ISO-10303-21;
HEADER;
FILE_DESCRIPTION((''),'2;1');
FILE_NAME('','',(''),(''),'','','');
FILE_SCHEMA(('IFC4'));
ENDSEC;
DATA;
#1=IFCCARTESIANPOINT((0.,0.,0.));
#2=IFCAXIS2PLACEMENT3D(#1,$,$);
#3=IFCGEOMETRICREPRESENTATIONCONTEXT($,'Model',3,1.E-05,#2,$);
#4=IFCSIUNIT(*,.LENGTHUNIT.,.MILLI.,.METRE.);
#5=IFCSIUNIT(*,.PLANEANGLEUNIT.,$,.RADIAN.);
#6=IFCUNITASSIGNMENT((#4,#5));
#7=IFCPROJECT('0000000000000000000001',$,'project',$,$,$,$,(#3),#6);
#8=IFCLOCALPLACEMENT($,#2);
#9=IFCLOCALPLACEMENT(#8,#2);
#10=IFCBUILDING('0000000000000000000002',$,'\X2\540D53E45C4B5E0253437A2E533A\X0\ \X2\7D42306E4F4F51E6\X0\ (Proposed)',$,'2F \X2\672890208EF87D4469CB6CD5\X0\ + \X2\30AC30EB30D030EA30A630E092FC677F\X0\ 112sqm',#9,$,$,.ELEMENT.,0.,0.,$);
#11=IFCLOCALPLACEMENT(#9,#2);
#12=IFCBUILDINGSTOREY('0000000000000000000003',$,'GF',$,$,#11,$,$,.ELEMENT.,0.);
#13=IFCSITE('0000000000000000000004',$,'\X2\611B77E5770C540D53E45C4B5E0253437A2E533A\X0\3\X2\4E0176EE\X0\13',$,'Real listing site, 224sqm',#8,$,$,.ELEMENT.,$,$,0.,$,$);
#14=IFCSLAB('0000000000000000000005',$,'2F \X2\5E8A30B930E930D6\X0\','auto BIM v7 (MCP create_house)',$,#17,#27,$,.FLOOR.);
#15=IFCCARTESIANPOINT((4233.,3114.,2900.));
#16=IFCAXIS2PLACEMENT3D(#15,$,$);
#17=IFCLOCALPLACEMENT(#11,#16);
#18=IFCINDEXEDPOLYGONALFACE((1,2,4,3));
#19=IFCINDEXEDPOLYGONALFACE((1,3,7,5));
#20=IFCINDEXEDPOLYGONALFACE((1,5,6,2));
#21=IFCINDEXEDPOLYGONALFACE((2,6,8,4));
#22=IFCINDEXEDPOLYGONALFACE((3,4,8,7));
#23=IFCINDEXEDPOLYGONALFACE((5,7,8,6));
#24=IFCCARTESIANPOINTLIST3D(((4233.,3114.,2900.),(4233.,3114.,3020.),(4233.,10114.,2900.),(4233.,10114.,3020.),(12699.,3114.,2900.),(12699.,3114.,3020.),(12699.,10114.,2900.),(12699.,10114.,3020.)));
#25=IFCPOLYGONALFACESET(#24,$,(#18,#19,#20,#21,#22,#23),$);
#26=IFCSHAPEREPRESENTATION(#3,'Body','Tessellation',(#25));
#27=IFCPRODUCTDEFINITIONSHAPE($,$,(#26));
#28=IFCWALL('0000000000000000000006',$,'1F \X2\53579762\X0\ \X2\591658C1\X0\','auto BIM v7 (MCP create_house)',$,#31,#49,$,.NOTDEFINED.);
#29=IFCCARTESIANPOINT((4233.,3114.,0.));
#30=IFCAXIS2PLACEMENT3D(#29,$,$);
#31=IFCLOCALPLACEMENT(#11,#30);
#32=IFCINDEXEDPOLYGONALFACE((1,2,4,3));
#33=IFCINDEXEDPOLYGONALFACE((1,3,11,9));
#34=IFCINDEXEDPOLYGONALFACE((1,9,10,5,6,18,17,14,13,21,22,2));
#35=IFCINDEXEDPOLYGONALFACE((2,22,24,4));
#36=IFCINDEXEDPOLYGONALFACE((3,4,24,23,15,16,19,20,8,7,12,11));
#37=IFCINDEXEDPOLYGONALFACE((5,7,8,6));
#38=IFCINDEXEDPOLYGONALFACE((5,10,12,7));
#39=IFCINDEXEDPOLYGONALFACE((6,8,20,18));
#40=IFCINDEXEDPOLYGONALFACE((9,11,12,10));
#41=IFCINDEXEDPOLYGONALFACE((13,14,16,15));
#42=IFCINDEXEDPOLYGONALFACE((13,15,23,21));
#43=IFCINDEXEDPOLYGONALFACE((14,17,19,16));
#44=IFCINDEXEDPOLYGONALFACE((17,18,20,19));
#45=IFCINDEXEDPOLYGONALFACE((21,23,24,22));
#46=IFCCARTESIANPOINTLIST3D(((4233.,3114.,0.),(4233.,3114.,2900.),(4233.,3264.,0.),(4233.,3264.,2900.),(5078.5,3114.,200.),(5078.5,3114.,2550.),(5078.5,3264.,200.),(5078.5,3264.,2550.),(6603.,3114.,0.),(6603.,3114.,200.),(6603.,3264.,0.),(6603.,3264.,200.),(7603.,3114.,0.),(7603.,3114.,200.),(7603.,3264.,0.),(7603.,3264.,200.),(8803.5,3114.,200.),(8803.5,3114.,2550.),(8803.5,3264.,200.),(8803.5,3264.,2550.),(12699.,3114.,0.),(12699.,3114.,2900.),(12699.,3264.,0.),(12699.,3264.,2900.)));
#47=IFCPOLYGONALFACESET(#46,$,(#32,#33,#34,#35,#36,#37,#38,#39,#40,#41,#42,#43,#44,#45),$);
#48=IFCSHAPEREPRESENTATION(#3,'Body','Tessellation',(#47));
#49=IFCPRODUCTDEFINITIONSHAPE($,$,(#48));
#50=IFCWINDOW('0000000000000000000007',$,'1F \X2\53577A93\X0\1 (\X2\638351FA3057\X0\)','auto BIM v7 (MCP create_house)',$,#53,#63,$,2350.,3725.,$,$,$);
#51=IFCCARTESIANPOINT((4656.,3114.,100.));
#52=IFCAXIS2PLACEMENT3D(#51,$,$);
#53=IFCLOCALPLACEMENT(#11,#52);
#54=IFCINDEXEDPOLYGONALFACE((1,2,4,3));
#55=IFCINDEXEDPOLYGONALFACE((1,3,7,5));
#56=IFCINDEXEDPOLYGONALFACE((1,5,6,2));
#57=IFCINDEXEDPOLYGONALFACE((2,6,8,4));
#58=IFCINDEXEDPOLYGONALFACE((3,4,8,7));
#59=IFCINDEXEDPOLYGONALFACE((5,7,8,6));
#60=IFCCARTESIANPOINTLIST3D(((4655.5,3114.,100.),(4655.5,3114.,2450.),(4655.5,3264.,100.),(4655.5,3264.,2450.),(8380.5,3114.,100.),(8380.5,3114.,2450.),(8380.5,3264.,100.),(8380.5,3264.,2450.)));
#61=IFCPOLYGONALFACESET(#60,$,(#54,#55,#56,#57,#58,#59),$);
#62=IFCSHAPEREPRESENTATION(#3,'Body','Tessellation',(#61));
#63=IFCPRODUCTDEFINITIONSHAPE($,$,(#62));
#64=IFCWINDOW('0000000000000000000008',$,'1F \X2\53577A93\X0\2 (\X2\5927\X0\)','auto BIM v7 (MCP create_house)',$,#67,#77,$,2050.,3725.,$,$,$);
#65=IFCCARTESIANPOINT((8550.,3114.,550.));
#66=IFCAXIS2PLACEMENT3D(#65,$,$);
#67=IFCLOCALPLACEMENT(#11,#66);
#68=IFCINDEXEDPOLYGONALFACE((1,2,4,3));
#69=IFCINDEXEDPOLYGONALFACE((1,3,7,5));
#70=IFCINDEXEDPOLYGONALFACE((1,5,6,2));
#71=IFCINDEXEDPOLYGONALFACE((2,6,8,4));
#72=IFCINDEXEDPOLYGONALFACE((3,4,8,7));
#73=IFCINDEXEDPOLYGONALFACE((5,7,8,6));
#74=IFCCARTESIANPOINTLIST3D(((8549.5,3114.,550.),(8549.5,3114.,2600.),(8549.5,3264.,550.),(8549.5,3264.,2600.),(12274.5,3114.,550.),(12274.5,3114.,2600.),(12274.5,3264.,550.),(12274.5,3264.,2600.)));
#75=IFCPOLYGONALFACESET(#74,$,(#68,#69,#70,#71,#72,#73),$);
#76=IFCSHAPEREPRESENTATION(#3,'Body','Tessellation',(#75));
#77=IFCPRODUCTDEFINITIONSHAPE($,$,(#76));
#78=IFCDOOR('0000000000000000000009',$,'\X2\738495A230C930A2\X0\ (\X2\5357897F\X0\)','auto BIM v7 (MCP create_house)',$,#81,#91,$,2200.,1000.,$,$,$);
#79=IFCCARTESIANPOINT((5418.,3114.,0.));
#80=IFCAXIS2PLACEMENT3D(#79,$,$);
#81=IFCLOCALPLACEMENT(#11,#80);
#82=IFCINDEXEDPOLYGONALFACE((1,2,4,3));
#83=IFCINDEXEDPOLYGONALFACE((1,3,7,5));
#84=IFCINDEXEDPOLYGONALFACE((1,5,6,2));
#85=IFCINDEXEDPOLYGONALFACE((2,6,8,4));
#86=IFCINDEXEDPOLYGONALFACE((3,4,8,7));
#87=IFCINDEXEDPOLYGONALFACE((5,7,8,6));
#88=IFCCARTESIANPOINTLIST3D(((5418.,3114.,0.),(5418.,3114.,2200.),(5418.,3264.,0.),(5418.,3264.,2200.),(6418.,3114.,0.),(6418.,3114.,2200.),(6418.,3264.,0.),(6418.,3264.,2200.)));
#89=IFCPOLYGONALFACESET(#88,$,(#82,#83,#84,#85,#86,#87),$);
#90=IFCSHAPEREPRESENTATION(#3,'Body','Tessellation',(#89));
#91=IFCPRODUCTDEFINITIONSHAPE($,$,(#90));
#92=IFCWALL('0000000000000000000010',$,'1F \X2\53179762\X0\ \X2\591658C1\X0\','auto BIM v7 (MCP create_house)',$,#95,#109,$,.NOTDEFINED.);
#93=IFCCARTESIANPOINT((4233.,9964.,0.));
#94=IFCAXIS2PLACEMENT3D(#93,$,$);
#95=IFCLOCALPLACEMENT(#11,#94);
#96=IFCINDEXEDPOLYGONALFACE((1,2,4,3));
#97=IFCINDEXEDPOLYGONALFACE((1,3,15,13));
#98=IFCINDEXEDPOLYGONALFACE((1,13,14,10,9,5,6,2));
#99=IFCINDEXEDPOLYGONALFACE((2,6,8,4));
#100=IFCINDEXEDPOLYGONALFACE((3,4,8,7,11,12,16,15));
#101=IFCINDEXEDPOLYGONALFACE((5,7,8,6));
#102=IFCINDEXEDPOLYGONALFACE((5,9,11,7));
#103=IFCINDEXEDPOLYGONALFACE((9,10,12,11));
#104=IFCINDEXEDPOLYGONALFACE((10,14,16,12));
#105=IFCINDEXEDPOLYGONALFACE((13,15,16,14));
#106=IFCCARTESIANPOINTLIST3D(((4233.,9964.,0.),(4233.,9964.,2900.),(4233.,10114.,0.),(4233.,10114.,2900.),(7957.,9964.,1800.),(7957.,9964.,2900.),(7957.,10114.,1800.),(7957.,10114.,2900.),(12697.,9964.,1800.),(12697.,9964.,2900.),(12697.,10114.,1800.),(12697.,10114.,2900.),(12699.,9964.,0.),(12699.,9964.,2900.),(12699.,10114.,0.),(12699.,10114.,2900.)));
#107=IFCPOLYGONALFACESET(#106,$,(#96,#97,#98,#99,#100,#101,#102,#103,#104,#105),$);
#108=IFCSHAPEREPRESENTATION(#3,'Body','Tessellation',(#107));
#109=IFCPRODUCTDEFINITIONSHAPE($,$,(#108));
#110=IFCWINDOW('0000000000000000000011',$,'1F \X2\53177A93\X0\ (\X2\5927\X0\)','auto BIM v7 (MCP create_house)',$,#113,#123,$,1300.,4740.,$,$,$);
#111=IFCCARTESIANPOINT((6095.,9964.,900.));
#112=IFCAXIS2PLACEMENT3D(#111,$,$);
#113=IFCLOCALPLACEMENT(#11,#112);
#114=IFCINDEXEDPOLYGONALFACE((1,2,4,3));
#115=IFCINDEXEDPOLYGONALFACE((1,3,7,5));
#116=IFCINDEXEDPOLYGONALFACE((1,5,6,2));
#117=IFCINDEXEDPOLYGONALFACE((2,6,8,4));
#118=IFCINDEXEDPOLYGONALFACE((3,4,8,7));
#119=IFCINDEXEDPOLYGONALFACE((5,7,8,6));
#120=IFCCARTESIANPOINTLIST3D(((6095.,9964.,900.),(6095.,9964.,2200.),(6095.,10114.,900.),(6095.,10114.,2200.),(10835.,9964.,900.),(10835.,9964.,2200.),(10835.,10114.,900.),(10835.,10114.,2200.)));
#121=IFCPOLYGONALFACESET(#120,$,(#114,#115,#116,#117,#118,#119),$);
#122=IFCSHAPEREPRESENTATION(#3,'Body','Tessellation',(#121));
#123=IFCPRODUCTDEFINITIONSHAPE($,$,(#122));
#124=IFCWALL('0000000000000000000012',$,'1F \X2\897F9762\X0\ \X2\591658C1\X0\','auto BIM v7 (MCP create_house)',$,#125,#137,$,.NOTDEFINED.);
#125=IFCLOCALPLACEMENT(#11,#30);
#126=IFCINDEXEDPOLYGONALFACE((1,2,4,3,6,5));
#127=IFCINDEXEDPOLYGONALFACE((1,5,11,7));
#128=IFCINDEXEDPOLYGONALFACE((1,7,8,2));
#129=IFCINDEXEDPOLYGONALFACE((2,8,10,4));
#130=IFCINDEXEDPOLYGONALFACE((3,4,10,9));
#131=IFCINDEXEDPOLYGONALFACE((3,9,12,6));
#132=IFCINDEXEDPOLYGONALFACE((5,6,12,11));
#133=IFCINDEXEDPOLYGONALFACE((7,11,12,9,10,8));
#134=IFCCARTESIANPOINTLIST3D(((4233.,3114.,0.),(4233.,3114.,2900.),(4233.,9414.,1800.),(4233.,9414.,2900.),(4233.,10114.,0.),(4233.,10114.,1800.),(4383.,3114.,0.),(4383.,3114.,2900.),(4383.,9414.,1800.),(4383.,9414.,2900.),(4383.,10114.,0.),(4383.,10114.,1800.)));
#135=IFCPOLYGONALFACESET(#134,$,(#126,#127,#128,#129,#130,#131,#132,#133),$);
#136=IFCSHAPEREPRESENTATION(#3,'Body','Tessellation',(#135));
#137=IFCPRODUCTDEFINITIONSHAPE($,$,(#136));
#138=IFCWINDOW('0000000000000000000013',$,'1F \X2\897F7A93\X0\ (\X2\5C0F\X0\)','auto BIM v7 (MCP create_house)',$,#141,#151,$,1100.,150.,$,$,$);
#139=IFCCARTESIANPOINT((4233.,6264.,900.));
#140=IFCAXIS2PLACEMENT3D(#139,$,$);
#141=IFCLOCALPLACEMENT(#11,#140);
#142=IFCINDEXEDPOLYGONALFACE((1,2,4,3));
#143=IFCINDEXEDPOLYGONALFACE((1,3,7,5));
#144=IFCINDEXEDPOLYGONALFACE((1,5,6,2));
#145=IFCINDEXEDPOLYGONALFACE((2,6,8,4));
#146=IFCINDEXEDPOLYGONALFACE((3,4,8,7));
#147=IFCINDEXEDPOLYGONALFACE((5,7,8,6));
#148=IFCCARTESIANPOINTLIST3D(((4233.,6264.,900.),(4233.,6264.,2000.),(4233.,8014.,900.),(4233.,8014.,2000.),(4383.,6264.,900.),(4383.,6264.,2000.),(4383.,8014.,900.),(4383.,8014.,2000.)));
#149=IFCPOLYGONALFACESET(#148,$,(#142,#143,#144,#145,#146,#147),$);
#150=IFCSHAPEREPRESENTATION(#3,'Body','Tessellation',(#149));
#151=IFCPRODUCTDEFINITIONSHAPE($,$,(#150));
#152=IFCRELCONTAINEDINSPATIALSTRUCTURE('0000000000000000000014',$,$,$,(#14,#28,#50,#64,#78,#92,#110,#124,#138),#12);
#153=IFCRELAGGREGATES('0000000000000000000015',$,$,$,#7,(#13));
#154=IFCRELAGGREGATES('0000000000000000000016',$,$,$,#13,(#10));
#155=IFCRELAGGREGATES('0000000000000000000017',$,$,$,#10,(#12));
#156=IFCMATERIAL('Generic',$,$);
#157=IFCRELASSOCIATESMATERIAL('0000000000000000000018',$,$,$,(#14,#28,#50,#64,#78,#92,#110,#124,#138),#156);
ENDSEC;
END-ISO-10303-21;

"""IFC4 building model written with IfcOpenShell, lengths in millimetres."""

from ifc_helpers import new_model, si_unit, frame, frame_2d, origin, place, context, project, spatial, rectangle, extrude, material, element, fill, save


model = new_model("IFC4")

# Units and contexts
model_context = context("Model", 3, precision=1e-05, world=origin())
ifc_project = project(units=[si_unit("LENGTHUNIT", "METRE", prefix="MILLI"), si_unit("PLANEANGLEUNIT", "RADIAN")], contexts=[model_context])

# Site, building, storey
site_placement = place(None, origin())
site = spatial("IfcSite", under=ifc_project, at=site_placement, Name="愛知県名古屋市千種区3丁目13", ObjectType="Real listing site, 224sqm", CompositionType="ELEMENT", RefElevation=0.0)
building_placement = place(site_placement, origin())
building = spatial("IfcBuilding", under=site, at=building_placement, Name="名古屋市千種区 終の住処 (Proposed)", ObjectType="2F 木造軸組構法 + ガルバリウム鋼板 112sqm", CompositionType="ELEMENT", ElevationOfRefHeight=0.0, ElevationOfTerrain=0.0)
storey_placement = place(building_placement, origin())
storey = spatial("IfcBuildingStorey", under=building, at=storey_placement, Name="GF", CompositionType="ELEMENT", Elevation=0.0)

# Slab
ifc_material = material(Name="Generic")
slab_1_placement = place(storey_placement, frame((4233.0, 3114.0, 2900.0)))
element("IfcSlab", 1, at=slab_1_placement, inside=storey, material=ifc_material, Name="2F 床スラブ", Description="auto BIM v7 (MCP create_house)", PredefinedType="FLOOR", context=model_context, shape_type="SweptSolid", body=[
    extrude(rectangle(XDim=8466.0, YDim=7000.0, at=frame_2d((4233.0, 3500.0))), frame((4233.0, 3114.0, 2900.0)), (0.0, 0.0, 1.0), 120.0),
])

# Wall, openings, windows, door
wall_1_placement = place(storey_placement, frame((4233.0, 3114.0, 0.0)))
wall_1 = element("IfcWall", 2, at=wall_1_placement, inside=storey, material=ifc_material, Name="1F 南面 外壁", Description="auto BIM v7 (MCP create_house)", PredefinedType="NOTDEFINED", context=model_context, shape_type="SweptSolid", body=[
    extrude(rectangle(XDim=8466.0, YDim=150.0, at=frame_2d((4233.0, 75.0))), frame((4233.0, 3114.0, 0.0)), (0.0, 0.0, 1.0), 2900.0),
])
opening_1_placement = place(storey_placement, frame((4656.0, 3114.0, 100.0)))
opening_1 = element("IfcOpeningElement", 3, at=opening_1_placement, cuts=wall_1, PredefinedType="NOTDEFINED", context=model_context, shape_type="SweptSolid", body=[
    extrude(rectangle(XDim=3725.0, YDim=150.0, at=frame_2d((1862.0, 75.0))), frame((4656.0, 3114.0, 100.0)), (0.0, 0.0, 1.0), 2350.0),
])
opening_2_placement = place(storey_placement, frame((8550.0, 3114.0, 550.0)))
opening_2 = element("IfcOpeningElement", 4, at=opening_2_placement, cuts=wall_1, PredefinedType="NOTDEFINED", context=model_context, shape_type="SweptSolid", body=[
    extrude(rectangle(XDim=3725.0, YDim=150.0, at=frame_2d((1862.0, 75.0))), frame((8550.0, 3114.0, 550.0)), (0.0, 0.0, 1.0), 2050.0),
])
opening_3_placement = place(storey_placement, frame((5418.0, 3114.0, 0.0)))
opening_3 = element("IfcOpeningElement", 5, at=opening_3_placement, cuts=wall_1, PredefinedType="NOTDEFINED", context=model_context, shape_type="SweptSolid", body=[
    extrude(rectangle(XDim=1000.0, YDim=150.0, at=frame_2d((500.0, 75.0))), frame((5418.0, 3114.0, 0.0)), (0.0, 0.0, 1.0), 2200.0),
])
window_1_placement = place(storey_placement, frame((4656.0, 3114.0, 100.0)))
window_1 = element("IfcWindow", 6, at=window_1_placement, inside=storey, material=ifc_material, Name="1F 南窓1 (掃出し)", Description="auto BIM v7 (MCP create_house)", OverallHeight=2350.0, OverallWidth=3725.0, context=model_context, shape_type="SweptSolid", body=[
    extrude(rectangle(XDim=3725.0, YDim=150.0, at=frame_2d((1862.0, 75.0))), frame((4656.0, 3114.0, 100.0)), (0.0, 0.0, 1.0), 2350.0),
])
fill(opening_1, window_1)
window_2_placement = place(storey_placement, frame((8550.0, 3114.0, 550.0)))
window_2 = element("IfcWindow", 7, at=window_2_placement, inside=storey, material=ifc_material, Name="1F 南窓2 (大)", Description="auto BIM v7 (MCP create_house)", OverallHeight=2050.0, OverallWidth=3725.0, context=model_context, shape_type="SweptSolid", body=[
    extrude(rectangle(XDim=3725.0, YDim=150.0, at=frame_2d((1862.0, 75.0))), frame((8550.0, 3114.0, 550.0)), (0.0, 0.0, 1.0), 2050.0),
])
fill(opening_2, window_2)
door_placement = place(storey_placement, frame((5418.0, 3114.0, 0.0)))
door = element("IfcDoor", 8, at=door_placement, inside=storey, material=ifc_material, Name="玄関ドア (南西)", Description="auto BIM v7 (MCP create_house)", OverallHeight=2200.0, OverallWidth=1000.0, context=model_context, shape_type="SweptSolid", body=[
    extrude(rectangle(XDim=1000.0, YDim=150.0, at=frame_2d((500.0, 75.0))), frame((5418.0, 3114.0, 0.0)), (0.0, 0.0, 1.0), 2200.0),
])
fill(opening_3, door)

# Walls, openings, windows
wall_2_placement = place(storey_placement, frame((4233.0, 9964.0, 0.0)))
wall_2 = element("IfcWall", 9, at=wall_2_placement, inside=storey, material=ifc_material, Name="1F 北面 外壁", Description="auto BIM v7 (MCP create_house)", PredefinedType="NOTDEFINED", context=model_context, shape_type="SweptSolid", body=[
    extrude(rectangle(XDim=8466.0, YDim=150.0, at=frame_2d((4233.0, 75.0))), frame((4233.0, 9964.0, 0.0)), (0.0, 0.0, 1.0), 2900.0),
])
opening_4_placement = place(storey_placement, frame((6095.0, 9964.0, 900.0)))
opening_4 = element("IfcOpeningElement", 10, at=opening_4_placement, cuts=wall_2, PredefinedType="NOTDEFINED", context=model_context, shape_type="SweptSolid", body=[
    extrude(rectangle(XDim=4740.0, YDim=150.0, at=frame_2d((2370.0, 75.0))), frame((6095.0, 9964.0, 900.0)), (0.0, 0.0, 1.0), 1300.0),
])
window_3_placement = place(storey_placement, frame((6095.0, 9964.0, 900.0)))
window_3 = element("IfcWindow", 11, at=window_3_placement, inside=storey, material=ifc_material, Name="1F 北窓 (大)", Description="auto BIM v7 (MCP create_house)", OverallHeight=1300.0, OverallWidth=4740.0, context=model_context, shape_type="SweptSolid", body=[
    extrude(rectangle(XDim=4740.0, YDim=150.0, at=frame_2d((2370.0, 75.0))), frame((6095.0, 9964.0, 900.0)), (0.0, 0.0, 1.0), 1300.0),
])
fill(opening_4, window_3)
wall_3_placement = place(storey_placement, frame((4233.0, 3114.0, 0.0)))
wall_3 = element("IfcWall", 12, at=wall_3_placement, inside=storey, material=ifc_material, Name="1F 西面 外壁", Description="auto BIM v7 (MCP create_house)", PredefinedType="NOTDEFINED", context=model_context, shape_type="SweptSolid", body=[
    extrude(rectangle(XDim=150.0, YDim=7000.0, at=frame_2d((75.0, 3500.0))), frame((4233.0, 3114.0, 0.0)), (0.0, 0.0, 1.0), 2900.0),
])
opening_5_placement = place(storey_placement, frame((4233.0, 6264.0, 900.0)))
opening_5 = element("IfcOpeningElement", 13, at=opening_5_placement, cuts=wall_3, PredefinedType="NOTDEFINED", context=model_context, shape_type="SweptSolid", body=[
    extrude(rectangle(XDim=150.0, YDim=1750.0, at=frame_2d((75.0, 875.0))), frame((4233.0, 6264.0, 900.0)), (0.0, 0.0, 1.0), 1100.0),
])
window_4_placement = place(storey_placement, frame((4233.0, 6264.0, 900.0)))
window_4 = element("IfcWindow", 14, at=window_4_placement, inside=storey, material=ifc_material, Name="1F 西窓 (小)", Description="auto BIM v7 (MCP create_house)", OverallHeight=1100.0, OverallWidth=150.0, context=model_context, shape_type="SweptSolid", body=[
    extrude(rectangle(XDim=150.0, YDim=1750.0, at=frame_2d((75.0, 875.0))), frame((4233.0, 6264.0, 900.0)), (0.0, 0.0, 1.0), 1100.0),
])
fill(opening_5, window_4)

save(model, "model.ifc")
